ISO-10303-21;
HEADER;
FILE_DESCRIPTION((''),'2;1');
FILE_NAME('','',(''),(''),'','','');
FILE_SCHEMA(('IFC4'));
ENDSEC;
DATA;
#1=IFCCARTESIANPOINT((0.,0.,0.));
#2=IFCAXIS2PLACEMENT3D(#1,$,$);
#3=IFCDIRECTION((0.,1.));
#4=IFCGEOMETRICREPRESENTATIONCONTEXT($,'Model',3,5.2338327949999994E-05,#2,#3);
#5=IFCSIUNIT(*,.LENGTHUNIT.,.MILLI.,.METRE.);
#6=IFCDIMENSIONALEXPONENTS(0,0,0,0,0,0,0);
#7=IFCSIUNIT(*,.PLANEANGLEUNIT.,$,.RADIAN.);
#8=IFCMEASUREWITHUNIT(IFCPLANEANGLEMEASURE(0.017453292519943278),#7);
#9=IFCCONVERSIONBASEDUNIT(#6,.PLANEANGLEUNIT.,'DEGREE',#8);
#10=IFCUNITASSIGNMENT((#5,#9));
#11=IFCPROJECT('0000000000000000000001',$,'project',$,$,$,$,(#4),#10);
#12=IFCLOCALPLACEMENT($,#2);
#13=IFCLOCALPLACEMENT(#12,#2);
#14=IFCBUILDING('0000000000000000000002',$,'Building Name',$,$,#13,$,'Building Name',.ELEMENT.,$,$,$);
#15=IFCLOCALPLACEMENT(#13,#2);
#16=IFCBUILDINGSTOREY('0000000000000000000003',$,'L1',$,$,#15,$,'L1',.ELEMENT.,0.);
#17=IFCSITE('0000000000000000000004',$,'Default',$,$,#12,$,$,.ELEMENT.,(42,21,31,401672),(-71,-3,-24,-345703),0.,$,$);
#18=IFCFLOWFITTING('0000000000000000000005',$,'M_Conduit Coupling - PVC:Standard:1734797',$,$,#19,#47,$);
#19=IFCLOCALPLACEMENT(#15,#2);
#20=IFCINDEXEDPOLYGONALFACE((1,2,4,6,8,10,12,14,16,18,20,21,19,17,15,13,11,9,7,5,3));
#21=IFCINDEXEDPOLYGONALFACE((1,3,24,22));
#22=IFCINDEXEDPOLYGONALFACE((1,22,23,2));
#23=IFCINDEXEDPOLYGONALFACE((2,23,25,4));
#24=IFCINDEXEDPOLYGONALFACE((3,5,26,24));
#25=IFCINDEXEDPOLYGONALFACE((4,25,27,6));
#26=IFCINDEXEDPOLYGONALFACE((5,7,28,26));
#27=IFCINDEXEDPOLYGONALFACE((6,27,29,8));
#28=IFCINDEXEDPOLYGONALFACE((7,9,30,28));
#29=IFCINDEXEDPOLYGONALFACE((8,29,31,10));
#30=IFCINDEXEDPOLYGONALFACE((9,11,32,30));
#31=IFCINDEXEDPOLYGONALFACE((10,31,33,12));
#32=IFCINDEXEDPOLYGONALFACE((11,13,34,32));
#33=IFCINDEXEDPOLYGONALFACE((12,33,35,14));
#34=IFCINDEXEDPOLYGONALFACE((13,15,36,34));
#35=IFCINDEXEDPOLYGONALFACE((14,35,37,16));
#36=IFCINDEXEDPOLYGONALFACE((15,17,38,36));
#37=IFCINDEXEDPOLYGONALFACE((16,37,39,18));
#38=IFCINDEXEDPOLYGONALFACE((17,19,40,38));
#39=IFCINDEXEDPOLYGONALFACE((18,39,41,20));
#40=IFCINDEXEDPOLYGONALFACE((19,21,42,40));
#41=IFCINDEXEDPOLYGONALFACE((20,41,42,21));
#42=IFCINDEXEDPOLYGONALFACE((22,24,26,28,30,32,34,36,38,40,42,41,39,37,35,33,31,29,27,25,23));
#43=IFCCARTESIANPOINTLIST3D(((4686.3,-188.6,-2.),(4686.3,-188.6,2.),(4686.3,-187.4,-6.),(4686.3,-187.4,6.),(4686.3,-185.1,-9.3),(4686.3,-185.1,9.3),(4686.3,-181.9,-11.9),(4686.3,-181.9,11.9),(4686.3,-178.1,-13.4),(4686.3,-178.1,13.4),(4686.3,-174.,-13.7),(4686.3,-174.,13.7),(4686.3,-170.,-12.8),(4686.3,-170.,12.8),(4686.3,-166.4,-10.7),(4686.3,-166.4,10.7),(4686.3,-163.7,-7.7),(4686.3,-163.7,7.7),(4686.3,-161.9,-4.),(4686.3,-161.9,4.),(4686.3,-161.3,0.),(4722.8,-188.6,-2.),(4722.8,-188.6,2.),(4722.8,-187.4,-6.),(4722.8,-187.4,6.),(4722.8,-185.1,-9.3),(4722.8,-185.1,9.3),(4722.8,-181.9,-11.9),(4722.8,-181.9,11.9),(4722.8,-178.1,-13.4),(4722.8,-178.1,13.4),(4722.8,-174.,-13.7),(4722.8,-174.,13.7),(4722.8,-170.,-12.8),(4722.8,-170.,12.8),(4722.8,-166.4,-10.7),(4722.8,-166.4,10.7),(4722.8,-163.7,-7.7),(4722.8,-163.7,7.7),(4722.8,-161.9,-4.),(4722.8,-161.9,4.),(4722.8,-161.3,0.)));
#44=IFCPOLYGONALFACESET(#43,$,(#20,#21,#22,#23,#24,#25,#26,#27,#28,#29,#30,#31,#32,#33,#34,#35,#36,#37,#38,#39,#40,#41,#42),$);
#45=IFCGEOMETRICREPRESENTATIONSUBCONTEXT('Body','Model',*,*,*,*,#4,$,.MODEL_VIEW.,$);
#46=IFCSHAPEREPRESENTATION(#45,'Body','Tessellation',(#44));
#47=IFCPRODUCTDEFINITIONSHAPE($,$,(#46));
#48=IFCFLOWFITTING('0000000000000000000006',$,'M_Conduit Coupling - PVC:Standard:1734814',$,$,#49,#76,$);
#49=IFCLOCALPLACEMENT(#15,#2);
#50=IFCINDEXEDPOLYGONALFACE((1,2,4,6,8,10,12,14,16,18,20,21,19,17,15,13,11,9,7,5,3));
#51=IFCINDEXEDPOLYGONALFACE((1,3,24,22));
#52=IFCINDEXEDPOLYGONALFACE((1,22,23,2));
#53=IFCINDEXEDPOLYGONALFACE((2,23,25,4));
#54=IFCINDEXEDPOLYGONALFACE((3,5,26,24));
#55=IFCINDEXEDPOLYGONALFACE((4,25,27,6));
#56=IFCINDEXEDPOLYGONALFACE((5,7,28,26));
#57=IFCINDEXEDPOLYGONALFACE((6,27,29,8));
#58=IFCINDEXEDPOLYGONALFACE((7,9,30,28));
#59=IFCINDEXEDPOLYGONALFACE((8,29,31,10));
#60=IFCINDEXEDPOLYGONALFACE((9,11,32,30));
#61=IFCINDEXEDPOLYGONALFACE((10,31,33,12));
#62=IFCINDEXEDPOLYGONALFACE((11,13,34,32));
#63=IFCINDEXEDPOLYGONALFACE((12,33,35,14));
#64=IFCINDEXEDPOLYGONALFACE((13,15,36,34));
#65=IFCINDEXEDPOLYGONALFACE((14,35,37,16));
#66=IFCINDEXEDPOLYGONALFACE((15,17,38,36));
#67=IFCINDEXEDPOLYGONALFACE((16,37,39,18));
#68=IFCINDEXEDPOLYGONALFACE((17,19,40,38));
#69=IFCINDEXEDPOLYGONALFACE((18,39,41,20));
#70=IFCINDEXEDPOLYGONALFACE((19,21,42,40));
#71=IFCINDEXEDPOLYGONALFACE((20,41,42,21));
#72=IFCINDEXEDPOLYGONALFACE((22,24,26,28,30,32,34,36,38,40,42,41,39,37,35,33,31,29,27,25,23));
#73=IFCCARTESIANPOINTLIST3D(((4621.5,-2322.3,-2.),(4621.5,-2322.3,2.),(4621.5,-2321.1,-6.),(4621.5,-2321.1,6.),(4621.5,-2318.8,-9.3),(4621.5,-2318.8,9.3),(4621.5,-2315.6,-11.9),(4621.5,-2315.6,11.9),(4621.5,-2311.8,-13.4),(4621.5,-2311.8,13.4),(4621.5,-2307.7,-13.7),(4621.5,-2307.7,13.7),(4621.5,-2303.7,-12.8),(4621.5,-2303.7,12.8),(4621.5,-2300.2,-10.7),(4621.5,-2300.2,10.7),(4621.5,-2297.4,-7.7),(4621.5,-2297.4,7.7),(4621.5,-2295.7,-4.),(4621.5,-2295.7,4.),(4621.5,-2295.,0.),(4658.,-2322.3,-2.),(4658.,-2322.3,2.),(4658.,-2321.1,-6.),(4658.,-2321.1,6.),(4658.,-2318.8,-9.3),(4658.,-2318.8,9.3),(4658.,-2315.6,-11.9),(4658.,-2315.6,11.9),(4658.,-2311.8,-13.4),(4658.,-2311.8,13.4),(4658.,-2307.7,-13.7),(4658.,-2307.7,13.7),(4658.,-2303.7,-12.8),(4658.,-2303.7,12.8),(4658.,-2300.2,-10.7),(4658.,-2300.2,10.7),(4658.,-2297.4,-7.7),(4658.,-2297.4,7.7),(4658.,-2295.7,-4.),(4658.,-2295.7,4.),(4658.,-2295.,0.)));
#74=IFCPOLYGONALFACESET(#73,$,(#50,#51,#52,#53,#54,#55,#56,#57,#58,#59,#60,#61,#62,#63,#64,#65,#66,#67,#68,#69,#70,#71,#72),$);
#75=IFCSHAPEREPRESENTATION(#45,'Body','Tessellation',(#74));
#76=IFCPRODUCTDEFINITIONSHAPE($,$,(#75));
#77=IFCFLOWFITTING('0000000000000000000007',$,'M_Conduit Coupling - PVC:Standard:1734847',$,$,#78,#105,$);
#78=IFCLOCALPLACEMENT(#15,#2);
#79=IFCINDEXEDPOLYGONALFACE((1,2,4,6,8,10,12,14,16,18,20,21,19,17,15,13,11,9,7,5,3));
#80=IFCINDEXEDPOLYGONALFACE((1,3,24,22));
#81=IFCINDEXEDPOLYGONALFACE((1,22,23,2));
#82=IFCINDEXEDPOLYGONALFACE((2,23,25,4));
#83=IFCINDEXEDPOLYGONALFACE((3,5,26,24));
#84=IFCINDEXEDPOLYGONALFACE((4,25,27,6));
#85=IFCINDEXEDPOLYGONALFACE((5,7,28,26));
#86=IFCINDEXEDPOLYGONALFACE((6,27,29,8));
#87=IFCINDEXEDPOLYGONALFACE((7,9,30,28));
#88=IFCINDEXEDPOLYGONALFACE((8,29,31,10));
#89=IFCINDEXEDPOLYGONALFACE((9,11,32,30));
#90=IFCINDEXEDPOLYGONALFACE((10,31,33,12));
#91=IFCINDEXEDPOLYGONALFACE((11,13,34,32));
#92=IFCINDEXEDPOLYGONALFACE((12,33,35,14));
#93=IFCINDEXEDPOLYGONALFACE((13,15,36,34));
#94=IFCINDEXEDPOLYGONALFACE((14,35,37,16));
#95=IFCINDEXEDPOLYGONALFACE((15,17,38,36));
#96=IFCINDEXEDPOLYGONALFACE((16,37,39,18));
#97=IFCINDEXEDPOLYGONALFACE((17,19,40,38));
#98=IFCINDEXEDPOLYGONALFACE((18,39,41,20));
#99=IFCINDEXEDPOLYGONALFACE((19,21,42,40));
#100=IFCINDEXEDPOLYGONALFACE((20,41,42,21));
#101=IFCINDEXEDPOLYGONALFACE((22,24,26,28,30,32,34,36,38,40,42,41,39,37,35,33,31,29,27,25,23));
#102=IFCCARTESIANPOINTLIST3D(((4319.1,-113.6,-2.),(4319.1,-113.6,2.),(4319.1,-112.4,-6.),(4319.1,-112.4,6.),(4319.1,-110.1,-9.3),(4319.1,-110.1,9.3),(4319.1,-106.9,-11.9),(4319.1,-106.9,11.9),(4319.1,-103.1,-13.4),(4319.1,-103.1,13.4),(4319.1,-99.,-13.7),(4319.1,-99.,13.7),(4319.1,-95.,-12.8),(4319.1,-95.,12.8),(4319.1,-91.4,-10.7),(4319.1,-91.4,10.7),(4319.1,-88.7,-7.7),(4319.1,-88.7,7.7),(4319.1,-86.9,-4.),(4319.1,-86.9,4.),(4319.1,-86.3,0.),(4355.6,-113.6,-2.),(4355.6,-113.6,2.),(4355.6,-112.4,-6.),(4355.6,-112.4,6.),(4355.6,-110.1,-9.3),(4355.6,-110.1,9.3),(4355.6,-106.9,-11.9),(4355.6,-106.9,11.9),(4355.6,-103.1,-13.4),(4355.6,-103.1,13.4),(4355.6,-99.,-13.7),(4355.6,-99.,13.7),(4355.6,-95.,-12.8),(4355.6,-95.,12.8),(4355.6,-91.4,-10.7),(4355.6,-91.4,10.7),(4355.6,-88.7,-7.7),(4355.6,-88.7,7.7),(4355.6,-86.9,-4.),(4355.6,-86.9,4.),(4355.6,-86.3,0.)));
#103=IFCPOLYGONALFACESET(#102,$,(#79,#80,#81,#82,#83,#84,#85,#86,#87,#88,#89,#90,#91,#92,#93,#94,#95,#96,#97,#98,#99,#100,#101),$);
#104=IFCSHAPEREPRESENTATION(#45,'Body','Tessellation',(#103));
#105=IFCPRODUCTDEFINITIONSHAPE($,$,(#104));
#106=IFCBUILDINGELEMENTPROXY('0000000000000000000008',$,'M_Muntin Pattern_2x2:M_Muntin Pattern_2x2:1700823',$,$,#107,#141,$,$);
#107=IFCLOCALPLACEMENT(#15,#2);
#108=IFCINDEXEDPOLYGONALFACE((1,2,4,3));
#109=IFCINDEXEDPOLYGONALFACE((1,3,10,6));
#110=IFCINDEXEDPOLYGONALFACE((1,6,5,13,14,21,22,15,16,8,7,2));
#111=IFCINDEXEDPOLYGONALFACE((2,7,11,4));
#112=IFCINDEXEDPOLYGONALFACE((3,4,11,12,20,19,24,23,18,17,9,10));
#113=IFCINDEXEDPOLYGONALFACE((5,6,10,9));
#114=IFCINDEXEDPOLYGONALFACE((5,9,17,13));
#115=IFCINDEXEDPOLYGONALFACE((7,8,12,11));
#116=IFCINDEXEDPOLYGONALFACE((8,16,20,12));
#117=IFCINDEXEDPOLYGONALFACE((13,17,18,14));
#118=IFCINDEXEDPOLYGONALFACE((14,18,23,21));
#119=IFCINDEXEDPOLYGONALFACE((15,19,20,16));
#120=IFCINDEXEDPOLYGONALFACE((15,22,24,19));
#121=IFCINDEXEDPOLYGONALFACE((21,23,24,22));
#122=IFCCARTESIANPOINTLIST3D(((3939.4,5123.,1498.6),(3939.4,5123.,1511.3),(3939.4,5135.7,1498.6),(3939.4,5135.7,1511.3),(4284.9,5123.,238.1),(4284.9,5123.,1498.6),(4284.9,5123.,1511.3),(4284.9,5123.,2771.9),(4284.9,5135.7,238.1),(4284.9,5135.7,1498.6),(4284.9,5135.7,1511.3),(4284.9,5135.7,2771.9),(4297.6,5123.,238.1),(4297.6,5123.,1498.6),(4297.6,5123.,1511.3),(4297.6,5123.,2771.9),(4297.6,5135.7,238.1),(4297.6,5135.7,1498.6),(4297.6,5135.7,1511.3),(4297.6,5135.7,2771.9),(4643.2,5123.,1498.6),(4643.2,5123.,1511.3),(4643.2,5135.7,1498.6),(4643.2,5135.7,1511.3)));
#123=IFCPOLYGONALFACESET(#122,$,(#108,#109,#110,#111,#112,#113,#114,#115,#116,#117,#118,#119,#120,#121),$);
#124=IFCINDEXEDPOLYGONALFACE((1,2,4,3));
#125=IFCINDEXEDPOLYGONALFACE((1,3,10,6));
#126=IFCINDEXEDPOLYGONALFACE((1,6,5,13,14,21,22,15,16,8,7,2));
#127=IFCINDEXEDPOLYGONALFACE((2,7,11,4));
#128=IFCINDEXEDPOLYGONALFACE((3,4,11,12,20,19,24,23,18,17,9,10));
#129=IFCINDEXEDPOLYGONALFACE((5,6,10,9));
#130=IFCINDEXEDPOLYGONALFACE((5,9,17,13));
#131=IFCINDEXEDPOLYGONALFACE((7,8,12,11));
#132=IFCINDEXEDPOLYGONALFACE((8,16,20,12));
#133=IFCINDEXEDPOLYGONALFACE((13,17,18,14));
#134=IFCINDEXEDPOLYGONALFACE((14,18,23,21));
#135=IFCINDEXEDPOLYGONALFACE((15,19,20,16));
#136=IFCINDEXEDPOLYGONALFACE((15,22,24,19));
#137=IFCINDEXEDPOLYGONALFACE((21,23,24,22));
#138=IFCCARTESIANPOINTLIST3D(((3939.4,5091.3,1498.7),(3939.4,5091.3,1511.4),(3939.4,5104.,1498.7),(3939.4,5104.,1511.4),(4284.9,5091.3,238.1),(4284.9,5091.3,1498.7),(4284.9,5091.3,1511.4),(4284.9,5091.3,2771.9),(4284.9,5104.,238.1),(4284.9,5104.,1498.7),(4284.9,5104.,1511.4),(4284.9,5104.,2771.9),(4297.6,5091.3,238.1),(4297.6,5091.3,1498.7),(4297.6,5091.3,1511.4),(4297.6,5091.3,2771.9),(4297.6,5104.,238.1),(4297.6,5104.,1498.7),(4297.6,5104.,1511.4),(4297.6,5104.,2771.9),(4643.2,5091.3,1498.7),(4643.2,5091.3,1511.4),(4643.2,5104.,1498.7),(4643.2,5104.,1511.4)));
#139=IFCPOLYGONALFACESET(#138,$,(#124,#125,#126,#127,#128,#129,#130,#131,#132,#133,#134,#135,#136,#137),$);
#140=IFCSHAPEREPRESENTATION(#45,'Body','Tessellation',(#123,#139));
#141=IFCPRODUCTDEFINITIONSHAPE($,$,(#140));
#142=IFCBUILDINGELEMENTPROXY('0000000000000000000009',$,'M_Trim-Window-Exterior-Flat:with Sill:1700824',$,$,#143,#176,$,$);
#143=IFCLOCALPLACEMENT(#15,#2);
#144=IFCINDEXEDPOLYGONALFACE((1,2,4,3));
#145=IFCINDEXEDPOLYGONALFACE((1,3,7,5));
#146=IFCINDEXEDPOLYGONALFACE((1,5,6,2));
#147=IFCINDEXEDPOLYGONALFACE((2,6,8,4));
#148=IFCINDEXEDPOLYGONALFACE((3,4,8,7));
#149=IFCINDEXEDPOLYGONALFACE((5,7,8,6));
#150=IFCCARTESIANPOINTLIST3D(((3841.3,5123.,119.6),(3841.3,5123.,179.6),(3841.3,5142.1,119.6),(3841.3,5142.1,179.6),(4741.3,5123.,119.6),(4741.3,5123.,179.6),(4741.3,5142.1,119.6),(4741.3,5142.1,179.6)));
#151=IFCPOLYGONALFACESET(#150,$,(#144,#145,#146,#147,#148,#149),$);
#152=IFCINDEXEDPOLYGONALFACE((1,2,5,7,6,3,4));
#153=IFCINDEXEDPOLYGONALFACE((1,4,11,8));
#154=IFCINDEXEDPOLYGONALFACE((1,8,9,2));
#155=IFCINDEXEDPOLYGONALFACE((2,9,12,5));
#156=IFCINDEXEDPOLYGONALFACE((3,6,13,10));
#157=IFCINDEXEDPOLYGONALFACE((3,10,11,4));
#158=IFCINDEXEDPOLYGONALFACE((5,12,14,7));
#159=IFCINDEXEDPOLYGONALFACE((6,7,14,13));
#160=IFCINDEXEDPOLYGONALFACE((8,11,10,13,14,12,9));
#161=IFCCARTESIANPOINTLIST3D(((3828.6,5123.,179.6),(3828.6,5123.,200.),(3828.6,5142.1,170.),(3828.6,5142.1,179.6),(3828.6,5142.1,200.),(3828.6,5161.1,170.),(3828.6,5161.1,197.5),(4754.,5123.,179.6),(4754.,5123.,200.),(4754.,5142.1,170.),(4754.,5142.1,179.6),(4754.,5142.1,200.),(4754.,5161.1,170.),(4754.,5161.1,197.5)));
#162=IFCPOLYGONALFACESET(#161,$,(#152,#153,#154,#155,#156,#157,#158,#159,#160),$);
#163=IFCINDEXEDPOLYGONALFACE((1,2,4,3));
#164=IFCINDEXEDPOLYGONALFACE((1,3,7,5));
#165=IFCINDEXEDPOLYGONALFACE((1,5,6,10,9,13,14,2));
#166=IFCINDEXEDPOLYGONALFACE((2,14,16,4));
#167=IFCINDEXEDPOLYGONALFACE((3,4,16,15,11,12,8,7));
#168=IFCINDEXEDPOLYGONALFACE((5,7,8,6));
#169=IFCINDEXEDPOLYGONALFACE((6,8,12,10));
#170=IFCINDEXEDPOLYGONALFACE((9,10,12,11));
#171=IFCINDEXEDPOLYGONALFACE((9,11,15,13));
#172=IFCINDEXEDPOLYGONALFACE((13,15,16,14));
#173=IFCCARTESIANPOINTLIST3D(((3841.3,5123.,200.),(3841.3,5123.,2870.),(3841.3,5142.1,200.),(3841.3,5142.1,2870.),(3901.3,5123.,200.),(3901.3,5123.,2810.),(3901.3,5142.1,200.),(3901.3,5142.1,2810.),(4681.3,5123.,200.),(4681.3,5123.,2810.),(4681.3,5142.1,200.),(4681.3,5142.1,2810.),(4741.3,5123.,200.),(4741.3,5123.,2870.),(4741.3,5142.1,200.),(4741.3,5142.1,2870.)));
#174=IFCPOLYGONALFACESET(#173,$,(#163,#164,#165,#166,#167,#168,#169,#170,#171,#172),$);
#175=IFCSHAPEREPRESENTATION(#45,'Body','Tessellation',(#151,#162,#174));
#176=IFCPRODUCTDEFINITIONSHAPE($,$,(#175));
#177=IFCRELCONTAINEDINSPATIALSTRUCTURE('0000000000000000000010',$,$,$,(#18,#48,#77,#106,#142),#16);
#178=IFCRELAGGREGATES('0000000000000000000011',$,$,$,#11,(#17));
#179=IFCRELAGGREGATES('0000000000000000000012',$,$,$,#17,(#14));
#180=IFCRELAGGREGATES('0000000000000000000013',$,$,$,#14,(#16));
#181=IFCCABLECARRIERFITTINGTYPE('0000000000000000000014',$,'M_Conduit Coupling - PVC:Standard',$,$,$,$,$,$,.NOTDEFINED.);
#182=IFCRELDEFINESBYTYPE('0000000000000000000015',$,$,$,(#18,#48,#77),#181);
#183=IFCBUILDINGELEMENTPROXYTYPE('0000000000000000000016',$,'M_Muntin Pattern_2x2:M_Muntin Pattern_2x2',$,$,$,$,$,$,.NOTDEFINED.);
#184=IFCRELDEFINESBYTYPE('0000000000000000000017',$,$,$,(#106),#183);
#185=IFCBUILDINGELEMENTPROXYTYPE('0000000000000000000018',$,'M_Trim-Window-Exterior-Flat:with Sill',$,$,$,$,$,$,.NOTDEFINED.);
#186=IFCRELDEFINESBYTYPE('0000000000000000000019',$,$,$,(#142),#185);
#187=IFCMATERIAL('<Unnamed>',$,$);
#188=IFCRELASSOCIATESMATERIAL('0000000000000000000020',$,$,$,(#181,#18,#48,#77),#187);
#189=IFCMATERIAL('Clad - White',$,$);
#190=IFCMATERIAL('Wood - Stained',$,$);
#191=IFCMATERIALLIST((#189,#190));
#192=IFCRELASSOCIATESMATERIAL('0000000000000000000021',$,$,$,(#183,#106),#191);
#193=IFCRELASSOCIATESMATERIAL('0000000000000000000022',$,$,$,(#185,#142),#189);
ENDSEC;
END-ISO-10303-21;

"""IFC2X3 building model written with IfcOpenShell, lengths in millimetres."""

from ifc_helpers import new_model, entity, si_unit, converted_unit, direction, frame, frame_2d, origin, place, context, subcontext, project, spatial, polyline, rectangle, circle, outline, extrude, source, transform, mapped, material, material_list, type_object, type_shapes, element, save


model = new_model("IFC2X3")

# Units and contexts
model_context = context("Model", 3, precision=5.2338327949999994e-05, world=origin(), true_north=direction((0.0, 1.0)))
body_context = subcontext(model_context, "Body", "Model", "MODEL_VIEW")
ifc_project = project(units=[si_unit("LENGTHUNIT", "METRE", prefix="MILLI"), converted_unit("PLANEANGLEUNIT", "DEGREE", entity("IfcPlaneAngleMeasure", 0.017453292519943278), si_unit("PLANEANGLEUNIT", "RADIAN"), dimensions=[0, 0, 0, 0, 0, 0, 0])], contexts=[model_context])

# Site, building, storey
site_placement = place(None, origin())
site = spatial("IfcSite", under=ifc_project, at=site_placement, Name="Default", CompositionType="ELEMENT", RefLatitude=(42, 21, 31, 401672), RefLongitude=(-71, -3, -24, -345703), RefElevation=0.0)
building_placement = place(site_placement, origin())
building = spatial("IfcBuilding", under=site, at=building_placement, Name="Building Name", LongName="Building Name", CompositionType="ELEMENT")
storey_placement = place(building_placement, origin())
storey = spatial("IfcBuildingStorey", under=building, at=storey_placement, Name="L1", LongName="L1", CompositionType="ELEMENT", Elevation=0.0)

# Shared definitions
ifc_material_1 = material(Name="<Unnamed>")

# Flow fittings
cable_carrier_fitting_type = type_object("IfcCableCarrierFittingType", Name="M_Conduit Coupling - PVC:Standard", PredefinedType="NOTDEFINED", material=ifc_material_1)
shared_shape_1 = source(origin(), body_context, "Body", "SweptSolid", [
    extrude(circle(Radius=13.7, at=frame_2d((0.0, 0.0), x_axis=(1.0, 0.0))), frame((0.0, 0.0, 0.0), z_axis=(1.0, 0.0, 0.0), x_axis=(0.0, 1.0, 0.0)), (0.0, 0.0, 1.0), 36.5),
])
type_shapes(cable_carrier_fitting_type, [shared_shape_1])
for number, where, name in (
    (1, (4686.3, -175.0, 0.0), "M_Conduit Coupling - PVC:Standard:1734797"),
    (2, (4621.5, -2308.8, 0.0), "M_Conduit Coupling - PVC:Standard:1734814"),
    (3, (4319.1, -100.0, 0.0), "M_Conduit Coupling - PVC:Standard:1734847"),
):
    element("IfcFlowFitting", number, at=place(storey_placement, frame(where)), inside=storey, type_object=cable_carrier_fitting_type, material=ifc_material_1, Name=name, context=body_context, shape_type="MappedRepresentation", body=[
        mapped(shared_shape_1, transform((0.0, 0.0, 0.0), scale=1.0)),
    ])

# Building element proxies
ifc_material_2 = material(Name="Clad - White")
ifc_material_3 = material(Name="Wood - Stained")
ifc_material_list = material_list([ifc_material_2, ifc_material_3])
building_element_proxy_type_1 = type_object("IfcBuildingElementProxyType", Name="M_Muntin Pattern_2x2:M_Muntin Pattern_2x2", PredefinedType="NOTDEFINED", material=ifc_material_list)
shared_shape_2 = source(origin(), body_context, "Body", "SweptSolid", [
    extrude(outline(polyline([(6.4, -6.4), (1266.9, -6.4), (1266.9, 6.3), (6.4, 6.3), (6.4, 351.9), (-6.3, 351.9), (-6.3, 6.3), (-1266.9, 6.3), (-1266.9, -6.4), (-6.3, -6.4), (-6.3, -351.9), (6.4, -351.9), (6.4, -6.4)])), frame((0.0, -22.2, 1266.9), z_axis=(0.0, 1.0, 0.0), x_axis=(0.0, 0.0, 1.0)), (0.0, 0.0, 1.0), 12.7),
    extrude(outline(polyline([(6.4, -6.4), (1266.9, -6.4), (1266.9, 6.3), (6.4, 6.3), (6.4, 351.9), (-6.3, 351.9), (-6.3, 6.3), (-1266.9, 6.3), (-1266.9, -6.4), (-6.3, -6.4), (-6.3, -351.9), (6.4, -351.9), (6.4, -6.4)])), frame((0.0, 9.5, 1266.9), z_axis=(0.0, 1.0, 0.0), x_axis=(0.0, 0.0, 1.0)), (0.0, 0.0, 1.0), 12.7),
])
type_shapes(building_element_proxy_type_1, [shared_shape_2])
proxy_1_placement = place(storey_placement, frame((4291.3, 5113.5, 238.1), z_axis=(0.0, 0.0, 1.0), x_axis=(-1.0, 0.0, 0.0)))
element("IfcBuildingElementProxy", 4, at=proxy_1_placement, inside=storey, type_object=building_element_proxy_type_1, material=ifc_material_list, Name="M_Muntin Pattern_2x2:M_Muntin Pattern_2x2:1700823", context=body_context, shape_type="MappedRepresentation", body=[
    mapped(shared_shape_2, transform((0.0, 0.0, 0.0), scale=1.0)),
])
building_element_proxy_type_2 = type_object("IfcBuildingElementProxyType", Name="M_Trim-Window-Exterior-Flat:with Sill", PredefinedType="NOTDEFINED", material=ifc_material_2)
shared_shape_3 = source(origin(), body_context, "Body", "SweptSolid", [
    extrude(rectangle(XDim=900.0, YDim=60.0, at=frame_2d((0.0, 0.0), x_axis=(1.0, 0.0))), frame((0.0, -2660.4, 0.0), z_axis=(0.0, 0.0, 1.0), x_axis=(-1.0, 0.0, 0.0)), (0.0, 0.0, 1.0), 19.0),
    extrude(outline(polyline([(-19.0, -15.2), (0.0, -15.2), (0.0, -5.7), (19.0, -5.7), (19.0, 14.8), (0.0, 14.8), (-19.0, 12.3), (-19.0, -15.2)])), frame((-462.7, -2624.8, 19.0), z_axis=(1.0, 0.0, 0.0), x_axis=(0.0, 0.0, -1.0)), (0.0, 0.0, 1.0), 925.4),
    extrude(outline(polyline([(-1350.0, -450.0), (1320.0, -450.0), (1320.0, -390.0), (-1290.0, -390.0), (-1290.0, 390.0), (1320.0, 390.0), (1320.0, 450.0), (-1350.0, 450.0), (-1350.0, -450.0)])), frame((0.0, -1290.0, 0.0), z_axis=(0.0, 0.0, 1.0), x_axis=(0.0, -1.0, 0.0)), (0.0, 0.0, 1.0), 19.0),
])
type_shapes(building_element_proxy_type_2, [shared_shape_3])
proxy_2_placement = place(storey_placement, frame((4291.3, 5123.0, 2810.0), z_axis=(0.0, 1.0, 0.0), x_axis=(-1.0, 0.0, 0.0)))
element("IfcBuildingElementProxy", 5, at=proxy_2_placement, inside=storey, type_object=building_element_proxy_type_2, material=ifc_material_2, Name="M_Trim-Window-Exterior-Flat:with Sill:1700824", context=body_context, shape_type="MappedRepresentation", body=[
    mapped(shared_shape_3, transform((0.0, 0.0, 0.0), scale=1.0)),
])

save(model, "model.ifc")
